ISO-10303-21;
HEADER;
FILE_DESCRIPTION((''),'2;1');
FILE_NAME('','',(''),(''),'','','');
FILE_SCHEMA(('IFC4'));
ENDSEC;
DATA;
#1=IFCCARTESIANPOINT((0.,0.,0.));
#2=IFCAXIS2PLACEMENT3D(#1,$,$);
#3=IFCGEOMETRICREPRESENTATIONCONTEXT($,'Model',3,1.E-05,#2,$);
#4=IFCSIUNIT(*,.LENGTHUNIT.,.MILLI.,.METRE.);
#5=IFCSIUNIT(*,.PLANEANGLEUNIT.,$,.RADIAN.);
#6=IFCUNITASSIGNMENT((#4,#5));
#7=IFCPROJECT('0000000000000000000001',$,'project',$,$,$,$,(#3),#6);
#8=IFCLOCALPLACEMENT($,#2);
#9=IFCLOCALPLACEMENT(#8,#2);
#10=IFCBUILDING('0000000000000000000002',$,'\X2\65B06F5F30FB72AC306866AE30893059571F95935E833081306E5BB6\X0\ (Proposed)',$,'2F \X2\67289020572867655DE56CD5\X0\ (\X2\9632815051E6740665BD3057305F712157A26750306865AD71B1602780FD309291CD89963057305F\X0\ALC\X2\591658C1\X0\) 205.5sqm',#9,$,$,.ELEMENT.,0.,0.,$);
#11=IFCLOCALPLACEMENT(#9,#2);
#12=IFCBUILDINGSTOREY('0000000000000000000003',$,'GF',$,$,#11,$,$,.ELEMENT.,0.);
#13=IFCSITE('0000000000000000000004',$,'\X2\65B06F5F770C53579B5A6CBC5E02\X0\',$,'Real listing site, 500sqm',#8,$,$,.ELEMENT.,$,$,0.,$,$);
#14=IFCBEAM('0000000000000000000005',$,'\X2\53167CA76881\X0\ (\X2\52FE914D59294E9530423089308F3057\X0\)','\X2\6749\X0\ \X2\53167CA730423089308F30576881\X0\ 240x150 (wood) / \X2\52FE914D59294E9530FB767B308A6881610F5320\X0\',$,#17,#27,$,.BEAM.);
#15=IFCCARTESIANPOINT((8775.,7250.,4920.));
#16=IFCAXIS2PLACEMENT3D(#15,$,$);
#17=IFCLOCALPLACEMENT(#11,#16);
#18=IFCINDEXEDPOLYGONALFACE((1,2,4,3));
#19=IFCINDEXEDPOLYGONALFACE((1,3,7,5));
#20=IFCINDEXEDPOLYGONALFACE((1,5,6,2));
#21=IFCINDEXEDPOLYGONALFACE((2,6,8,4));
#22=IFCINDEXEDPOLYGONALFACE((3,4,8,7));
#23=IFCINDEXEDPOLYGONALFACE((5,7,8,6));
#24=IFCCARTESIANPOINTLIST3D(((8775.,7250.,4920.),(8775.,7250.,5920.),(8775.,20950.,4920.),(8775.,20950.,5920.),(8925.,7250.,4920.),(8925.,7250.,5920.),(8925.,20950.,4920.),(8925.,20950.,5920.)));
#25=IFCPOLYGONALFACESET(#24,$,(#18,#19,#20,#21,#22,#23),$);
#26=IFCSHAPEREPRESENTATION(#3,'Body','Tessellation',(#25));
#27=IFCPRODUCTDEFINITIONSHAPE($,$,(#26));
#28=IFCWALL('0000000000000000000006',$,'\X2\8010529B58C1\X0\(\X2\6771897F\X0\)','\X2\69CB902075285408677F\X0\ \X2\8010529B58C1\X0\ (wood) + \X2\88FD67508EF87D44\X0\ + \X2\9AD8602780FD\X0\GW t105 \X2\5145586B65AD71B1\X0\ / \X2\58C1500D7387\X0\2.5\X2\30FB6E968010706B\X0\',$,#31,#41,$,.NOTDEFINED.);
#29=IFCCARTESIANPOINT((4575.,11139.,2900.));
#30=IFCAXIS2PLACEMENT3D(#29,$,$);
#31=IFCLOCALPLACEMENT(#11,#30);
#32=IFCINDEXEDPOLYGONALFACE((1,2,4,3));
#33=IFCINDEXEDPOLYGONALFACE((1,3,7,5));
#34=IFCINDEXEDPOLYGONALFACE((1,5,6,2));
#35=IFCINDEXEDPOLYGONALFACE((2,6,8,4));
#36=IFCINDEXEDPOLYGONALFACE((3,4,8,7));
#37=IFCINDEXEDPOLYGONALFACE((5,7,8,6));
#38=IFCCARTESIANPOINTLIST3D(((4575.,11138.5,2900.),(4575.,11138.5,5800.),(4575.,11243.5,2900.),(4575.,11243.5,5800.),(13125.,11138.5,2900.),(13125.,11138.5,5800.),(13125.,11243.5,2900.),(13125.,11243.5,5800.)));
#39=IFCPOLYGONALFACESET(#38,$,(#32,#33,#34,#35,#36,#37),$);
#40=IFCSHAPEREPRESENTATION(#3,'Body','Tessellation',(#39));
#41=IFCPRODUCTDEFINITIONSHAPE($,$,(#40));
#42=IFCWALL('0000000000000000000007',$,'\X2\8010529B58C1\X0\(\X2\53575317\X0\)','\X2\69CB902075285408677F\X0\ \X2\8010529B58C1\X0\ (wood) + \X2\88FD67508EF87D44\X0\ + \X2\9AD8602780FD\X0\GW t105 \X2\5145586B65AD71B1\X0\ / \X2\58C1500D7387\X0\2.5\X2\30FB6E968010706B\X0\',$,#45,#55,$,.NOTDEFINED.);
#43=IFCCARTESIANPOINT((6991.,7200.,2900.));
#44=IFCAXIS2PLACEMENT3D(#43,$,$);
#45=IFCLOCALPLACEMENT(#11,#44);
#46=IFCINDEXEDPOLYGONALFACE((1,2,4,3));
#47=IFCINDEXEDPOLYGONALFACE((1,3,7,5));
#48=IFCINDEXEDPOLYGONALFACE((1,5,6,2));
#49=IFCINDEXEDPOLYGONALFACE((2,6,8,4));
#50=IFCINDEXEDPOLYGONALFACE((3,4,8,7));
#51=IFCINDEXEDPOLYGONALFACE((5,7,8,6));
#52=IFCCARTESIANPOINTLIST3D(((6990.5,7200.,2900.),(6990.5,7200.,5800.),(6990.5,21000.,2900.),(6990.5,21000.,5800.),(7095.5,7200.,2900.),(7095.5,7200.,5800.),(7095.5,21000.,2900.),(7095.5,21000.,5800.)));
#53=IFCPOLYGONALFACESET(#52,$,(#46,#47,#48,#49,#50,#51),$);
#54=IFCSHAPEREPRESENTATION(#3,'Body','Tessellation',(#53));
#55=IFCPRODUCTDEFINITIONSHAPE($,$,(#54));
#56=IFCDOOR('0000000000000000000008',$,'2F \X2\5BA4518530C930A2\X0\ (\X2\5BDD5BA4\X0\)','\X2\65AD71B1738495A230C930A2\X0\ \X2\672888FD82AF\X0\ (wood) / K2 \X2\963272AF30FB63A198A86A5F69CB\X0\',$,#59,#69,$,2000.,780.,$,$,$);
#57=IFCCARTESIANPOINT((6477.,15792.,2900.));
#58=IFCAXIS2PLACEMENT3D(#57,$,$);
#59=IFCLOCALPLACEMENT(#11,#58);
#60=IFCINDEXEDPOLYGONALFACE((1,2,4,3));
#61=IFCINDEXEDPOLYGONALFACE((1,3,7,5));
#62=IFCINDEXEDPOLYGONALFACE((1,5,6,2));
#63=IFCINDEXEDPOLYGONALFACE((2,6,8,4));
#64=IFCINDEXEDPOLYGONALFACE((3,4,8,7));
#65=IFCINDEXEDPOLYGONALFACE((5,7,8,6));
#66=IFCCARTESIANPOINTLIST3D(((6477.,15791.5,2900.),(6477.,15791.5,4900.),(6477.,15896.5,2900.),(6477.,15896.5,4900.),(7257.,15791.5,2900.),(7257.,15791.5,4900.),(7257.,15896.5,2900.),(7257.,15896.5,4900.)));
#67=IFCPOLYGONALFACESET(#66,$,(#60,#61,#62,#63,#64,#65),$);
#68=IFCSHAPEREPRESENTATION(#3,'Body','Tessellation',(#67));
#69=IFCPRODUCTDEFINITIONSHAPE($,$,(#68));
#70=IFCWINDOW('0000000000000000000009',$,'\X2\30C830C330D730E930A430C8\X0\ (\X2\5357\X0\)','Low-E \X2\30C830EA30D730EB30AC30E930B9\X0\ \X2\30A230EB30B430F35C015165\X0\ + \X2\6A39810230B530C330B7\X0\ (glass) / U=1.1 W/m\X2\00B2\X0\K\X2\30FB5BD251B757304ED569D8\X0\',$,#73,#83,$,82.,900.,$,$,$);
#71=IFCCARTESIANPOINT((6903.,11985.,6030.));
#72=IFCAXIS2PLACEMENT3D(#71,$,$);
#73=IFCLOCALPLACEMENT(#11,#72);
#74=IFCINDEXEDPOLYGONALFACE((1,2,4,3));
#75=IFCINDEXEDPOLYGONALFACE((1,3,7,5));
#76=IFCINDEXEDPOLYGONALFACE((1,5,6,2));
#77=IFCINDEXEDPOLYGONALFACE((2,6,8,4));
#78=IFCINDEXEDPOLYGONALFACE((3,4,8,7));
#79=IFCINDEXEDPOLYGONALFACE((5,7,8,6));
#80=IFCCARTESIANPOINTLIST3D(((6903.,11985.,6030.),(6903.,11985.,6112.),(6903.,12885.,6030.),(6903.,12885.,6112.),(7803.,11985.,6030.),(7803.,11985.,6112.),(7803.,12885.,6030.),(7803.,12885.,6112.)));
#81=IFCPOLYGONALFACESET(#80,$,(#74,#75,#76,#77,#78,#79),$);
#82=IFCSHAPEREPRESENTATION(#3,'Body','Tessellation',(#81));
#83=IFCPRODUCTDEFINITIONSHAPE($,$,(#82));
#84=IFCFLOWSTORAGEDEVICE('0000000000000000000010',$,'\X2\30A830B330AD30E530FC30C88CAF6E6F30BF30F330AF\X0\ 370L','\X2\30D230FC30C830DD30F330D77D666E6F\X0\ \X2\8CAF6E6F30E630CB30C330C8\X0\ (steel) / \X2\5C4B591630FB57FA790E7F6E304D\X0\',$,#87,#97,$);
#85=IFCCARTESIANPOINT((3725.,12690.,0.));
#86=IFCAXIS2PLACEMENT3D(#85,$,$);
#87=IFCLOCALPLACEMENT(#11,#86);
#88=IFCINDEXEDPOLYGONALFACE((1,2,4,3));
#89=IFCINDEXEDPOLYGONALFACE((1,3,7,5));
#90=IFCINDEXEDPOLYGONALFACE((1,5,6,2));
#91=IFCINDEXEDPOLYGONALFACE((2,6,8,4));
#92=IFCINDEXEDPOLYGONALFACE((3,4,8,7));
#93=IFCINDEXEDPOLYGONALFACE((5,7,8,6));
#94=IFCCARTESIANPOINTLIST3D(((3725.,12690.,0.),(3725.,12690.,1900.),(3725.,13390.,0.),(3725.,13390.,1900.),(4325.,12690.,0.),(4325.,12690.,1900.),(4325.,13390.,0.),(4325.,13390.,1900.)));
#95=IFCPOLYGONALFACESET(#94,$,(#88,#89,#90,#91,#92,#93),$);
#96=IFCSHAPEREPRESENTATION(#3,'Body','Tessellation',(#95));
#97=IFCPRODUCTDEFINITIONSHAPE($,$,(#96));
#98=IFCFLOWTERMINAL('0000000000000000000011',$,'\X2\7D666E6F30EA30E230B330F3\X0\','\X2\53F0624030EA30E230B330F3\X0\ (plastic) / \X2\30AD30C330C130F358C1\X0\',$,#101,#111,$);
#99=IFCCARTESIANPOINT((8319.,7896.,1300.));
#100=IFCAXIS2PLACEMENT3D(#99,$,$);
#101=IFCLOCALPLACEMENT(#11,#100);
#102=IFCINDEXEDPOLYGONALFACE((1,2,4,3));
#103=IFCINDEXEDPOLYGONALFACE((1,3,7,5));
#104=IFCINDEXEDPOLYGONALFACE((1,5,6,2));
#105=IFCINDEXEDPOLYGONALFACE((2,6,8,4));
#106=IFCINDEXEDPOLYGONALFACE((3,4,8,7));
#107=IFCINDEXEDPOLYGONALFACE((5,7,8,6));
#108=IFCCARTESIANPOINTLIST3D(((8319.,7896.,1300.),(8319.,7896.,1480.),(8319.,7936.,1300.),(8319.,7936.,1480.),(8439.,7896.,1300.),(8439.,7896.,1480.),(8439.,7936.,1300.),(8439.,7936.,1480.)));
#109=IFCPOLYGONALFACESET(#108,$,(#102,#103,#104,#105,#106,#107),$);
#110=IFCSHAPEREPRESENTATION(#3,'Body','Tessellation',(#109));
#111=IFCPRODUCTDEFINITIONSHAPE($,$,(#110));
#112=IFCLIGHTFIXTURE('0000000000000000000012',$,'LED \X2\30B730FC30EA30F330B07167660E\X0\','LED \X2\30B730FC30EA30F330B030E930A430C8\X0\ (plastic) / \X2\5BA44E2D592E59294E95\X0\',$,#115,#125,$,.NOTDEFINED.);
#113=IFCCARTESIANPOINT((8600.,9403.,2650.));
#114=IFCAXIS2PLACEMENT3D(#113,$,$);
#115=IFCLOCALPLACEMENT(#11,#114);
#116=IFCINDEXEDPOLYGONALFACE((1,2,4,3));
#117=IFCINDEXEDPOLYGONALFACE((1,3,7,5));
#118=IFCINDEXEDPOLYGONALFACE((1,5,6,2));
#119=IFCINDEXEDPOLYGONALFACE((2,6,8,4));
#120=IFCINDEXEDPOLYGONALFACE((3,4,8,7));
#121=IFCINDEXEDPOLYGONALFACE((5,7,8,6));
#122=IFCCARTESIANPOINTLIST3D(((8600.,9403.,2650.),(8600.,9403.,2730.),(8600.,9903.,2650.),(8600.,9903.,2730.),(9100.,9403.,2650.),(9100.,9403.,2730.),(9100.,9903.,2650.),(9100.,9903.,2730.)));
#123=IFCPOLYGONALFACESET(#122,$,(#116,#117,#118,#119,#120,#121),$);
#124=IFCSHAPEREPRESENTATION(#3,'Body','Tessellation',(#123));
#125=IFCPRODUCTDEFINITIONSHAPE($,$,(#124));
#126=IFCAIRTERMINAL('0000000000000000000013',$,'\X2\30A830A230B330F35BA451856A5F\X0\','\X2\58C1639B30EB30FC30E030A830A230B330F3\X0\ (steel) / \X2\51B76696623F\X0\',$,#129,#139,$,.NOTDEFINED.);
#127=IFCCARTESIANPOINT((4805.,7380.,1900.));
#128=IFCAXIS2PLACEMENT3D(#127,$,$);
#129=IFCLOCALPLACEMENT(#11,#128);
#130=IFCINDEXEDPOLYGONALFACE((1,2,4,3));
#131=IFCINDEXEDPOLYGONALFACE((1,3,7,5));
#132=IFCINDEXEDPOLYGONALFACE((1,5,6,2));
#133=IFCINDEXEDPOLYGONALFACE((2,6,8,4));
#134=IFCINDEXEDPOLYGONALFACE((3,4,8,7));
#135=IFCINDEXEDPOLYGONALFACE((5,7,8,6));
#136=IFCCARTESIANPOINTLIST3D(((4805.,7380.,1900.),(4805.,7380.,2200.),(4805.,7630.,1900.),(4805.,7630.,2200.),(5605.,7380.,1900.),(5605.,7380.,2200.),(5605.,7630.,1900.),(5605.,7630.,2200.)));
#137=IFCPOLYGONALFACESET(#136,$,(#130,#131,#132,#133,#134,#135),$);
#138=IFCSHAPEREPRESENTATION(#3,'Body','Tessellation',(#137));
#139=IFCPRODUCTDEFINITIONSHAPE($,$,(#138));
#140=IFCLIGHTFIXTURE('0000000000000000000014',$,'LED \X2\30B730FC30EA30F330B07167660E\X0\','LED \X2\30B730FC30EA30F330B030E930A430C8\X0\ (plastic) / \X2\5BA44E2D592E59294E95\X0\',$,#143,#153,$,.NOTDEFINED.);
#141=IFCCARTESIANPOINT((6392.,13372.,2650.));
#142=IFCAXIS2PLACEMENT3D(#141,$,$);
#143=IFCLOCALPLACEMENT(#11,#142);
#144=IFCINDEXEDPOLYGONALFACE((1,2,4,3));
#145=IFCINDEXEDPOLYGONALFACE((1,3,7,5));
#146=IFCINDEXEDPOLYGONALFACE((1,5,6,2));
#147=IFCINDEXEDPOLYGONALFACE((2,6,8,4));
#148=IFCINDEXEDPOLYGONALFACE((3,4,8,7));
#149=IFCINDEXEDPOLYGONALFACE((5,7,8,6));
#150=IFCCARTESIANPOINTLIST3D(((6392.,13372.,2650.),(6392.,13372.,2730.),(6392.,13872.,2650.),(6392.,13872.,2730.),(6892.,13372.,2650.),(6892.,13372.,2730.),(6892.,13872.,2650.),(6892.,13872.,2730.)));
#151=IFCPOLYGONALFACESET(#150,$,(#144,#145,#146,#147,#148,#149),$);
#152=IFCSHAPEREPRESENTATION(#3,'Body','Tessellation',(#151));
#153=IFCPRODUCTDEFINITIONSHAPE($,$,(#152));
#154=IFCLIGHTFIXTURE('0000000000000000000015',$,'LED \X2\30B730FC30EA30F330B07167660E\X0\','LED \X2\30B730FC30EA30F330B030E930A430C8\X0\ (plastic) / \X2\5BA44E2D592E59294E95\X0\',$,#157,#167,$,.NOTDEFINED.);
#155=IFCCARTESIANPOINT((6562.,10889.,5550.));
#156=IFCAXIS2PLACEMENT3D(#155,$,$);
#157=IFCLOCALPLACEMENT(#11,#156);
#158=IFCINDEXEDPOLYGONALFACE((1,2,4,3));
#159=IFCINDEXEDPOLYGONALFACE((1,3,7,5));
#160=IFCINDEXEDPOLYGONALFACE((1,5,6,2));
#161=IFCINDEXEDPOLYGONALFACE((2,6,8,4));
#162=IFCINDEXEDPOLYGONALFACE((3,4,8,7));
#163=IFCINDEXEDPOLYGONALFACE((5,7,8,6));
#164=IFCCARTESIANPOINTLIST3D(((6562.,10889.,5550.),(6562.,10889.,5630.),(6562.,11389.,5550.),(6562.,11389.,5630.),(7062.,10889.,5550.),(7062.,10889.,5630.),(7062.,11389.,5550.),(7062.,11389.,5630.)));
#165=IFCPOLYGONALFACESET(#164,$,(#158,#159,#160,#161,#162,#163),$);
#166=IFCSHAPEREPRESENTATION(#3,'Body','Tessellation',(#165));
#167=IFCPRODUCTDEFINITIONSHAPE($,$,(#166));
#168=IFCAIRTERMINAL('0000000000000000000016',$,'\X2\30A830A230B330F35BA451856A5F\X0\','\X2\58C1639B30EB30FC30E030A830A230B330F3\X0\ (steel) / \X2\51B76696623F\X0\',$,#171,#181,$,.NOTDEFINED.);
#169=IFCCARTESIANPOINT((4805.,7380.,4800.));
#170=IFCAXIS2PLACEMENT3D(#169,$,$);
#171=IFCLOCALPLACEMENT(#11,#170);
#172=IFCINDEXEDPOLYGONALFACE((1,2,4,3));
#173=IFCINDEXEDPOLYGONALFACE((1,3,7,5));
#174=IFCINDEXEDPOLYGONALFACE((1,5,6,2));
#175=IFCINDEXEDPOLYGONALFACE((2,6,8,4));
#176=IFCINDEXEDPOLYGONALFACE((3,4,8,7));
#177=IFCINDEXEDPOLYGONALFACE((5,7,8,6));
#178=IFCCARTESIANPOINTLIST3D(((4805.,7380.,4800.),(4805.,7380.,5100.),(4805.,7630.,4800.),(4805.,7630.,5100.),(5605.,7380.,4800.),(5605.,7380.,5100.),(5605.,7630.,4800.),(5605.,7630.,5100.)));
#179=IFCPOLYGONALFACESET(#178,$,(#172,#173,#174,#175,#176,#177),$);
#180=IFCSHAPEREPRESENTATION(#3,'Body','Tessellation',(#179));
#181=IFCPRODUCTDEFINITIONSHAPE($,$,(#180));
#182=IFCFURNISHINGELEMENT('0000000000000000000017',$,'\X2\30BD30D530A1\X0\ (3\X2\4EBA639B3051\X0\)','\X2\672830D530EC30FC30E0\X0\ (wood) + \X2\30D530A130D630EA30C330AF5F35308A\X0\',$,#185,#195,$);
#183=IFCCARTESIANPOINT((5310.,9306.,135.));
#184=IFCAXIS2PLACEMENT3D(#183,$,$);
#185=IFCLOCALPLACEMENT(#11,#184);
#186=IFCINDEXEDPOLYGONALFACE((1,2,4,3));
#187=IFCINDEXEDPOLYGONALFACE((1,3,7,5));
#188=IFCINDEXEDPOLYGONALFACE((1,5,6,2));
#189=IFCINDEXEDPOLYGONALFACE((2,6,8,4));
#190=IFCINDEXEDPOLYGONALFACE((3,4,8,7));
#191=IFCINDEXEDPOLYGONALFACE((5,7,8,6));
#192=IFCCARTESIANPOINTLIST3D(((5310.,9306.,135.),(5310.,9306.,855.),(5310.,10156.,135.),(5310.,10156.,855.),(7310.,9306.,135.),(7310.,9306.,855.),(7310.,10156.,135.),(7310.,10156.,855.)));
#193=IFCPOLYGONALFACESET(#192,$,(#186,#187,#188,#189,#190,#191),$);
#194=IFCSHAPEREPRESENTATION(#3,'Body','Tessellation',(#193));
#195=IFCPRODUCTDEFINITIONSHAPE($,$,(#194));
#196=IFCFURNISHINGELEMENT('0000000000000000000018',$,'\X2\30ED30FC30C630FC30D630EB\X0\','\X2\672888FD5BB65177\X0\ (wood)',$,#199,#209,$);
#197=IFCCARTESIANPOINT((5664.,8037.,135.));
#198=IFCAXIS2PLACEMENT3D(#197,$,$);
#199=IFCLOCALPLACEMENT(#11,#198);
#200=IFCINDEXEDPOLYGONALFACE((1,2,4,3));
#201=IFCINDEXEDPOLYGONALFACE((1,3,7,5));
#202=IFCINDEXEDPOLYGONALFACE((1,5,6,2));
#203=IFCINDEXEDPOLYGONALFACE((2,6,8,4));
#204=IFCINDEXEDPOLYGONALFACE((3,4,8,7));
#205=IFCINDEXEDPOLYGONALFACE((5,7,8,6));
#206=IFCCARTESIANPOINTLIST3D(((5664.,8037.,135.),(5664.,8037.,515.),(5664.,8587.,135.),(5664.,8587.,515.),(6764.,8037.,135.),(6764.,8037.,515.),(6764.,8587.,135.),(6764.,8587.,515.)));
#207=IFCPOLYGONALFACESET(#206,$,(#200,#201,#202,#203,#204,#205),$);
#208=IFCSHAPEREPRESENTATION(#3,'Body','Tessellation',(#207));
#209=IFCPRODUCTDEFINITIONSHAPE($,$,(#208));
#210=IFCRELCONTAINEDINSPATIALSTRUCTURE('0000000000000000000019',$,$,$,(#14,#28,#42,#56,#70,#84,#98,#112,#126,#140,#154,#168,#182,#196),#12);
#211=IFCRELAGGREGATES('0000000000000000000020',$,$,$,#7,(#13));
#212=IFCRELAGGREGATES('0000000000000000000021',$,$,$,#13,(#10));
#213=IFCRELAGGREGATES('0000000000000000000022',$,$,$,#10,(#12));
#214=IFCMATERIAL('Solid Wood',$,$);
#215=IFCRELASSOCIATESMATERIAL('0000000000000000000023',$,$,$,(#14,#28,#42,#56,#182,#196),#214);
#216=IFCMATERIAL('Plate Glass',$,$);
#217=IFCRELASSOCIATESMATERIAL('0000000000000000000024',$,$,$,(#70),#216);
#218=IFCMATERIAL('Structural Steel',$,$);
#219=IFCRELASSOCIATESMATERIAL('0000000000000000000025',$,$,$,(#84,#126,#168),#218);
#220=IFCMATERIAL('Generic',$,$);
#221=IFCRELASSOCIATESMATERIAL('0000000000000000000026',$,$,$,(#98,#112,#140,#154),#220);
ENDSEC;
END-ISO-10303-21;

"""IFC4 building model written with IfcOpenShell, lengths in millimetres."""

from ifc_helpers import new_model, si_unit, frame, frame_2d, origin, place, context, project, spatial, rectangle, extrude, material, element, fill, save


model = new_model("IFC4")

# Units and contexts
model_context = context("Model", 3, precision=1e-05, world=origin())
ifc_project = project(units=[si_unit("LENGTHUNIT", "METRE", prefix="MILLI"), si_unit("PLANEANGLEUNIT", "RADIAN")], contexts=[model_context])

# Site, building, storey
site_placement = place(None, origin())
site = spatial("IfcSite", under=ifc_project, at=site_placement, Name="新潟県南魚沼市", ObjectType="Real listing site, 500sqm", CompositionType="ELEMENT", RefElevation=0.0)
building_placement = place(site_placement, origin())
building = spatial("IfcBuilding", under=site, at=building_placement, Name="新潟・犬と暮らす土間広めの家 (Proposed)", ObjectType="2F 木造在来工法 (防腐処理施した無垢材と断熱性能を重視したALC外壁) 205.5sqm", CompositionType="ELEMENT", ElevationOfRefHeight=0.0, ElevationOfTerrain=0.0)
storey_placement = place(building_placement, origin())
storey = spatial("IfcBuildingStorey", under=building, at=storey_placement, Name="GF", CompositionType="ELEMENT", Elevation=0.0)

# Shared definitions
ifc_material_1 = material(Name="Solid Wood")

# Beam
beam_placement = place(storey_placement, frame((8775.0, 7250.0, 4920.0)))
element("IfcBeam", 1, at=beam_placement, inside=storey, material=ifc_material_1, Name="化粧梁 (勾配天井あらわし)", Description="杉 化粧あらわし梁 240x150 (wood) / 勾配天井・登り梁意匠", PredefinedType="BEAM", context=model_context, shape_type="SweptSolid", body=[
    extrude(rectangle(XDim=150.0, YDim=13700.0, at=frame_2d((75.0, 6850.0))), frame((8775.0, 7250.0, 4920.0)), (0.0, 0.0, 1.0), 1000.0),
])

# Wall
wall_1_placement = place(storey_placement, frame((4575.0, 11139.0, 2900.0)))
element("IfcWall", 2, at=wall_1_placement, inside=storey, material=ifc_material_1, Name="耐力壁(東西)", Description="構造用合板 耐力壁 (wood) + 製材軸組 + 高性能GW t105 充填断熱 / 壁倍率2.5・準耐火", PredefinedType="NOTDEFINED", context=model_context, shape_type="SweptSolid", body=[
    extrude(rectangle(XDim=8550.0, YDim=105.0, at=frame_2d((4275.0, 52.0))), frame((4575.0, 11139.0, 2900.0)), (0.0, 0.0, 1.0), 2900.0),
])

# Wall, opening, door
wall_2_placement = place(storey_placement, frame((6991.0, 7200.0, 2900.0)))
wall_2 = element("IfcWall", 3, at=wall_2_placement, inside=storey, material=ifc_material_1, Name="耐力壁(南北)", Description="構造用合板 耐力壁 (wood) + 製材軸組 + 高性能GW t105 充填断熱 / 壁倍率2.5・準耐火", PredefinedType="NOTDEFINED", context=model_context, shape_type="SweptSolid", body=[
    extrude(rectangle(XDim=105.0, YDim=13800.0, at=frame_2d((52.0, 6900.0))), frame((6991.0, 7200.0, 2900.0)), (0.0, 0.0, 1.0), 2900.0),
])
opening_placement = place(storey_placement, frame((6477.0, 15792.0, 2900.0)))
opening = element("IfcOpeningElement", 4, at=opening_placement, cuts=wall_2, PredefinedType="NOTDEFINED", context=model_context, shape_type="SweptSolid", body=[
    extrude(rectangle(XDim=780.0, YDim=105.0, at=frame_2d((390.0, 52.0))), frame((6477.0, 15792.0, 2900.0)), (0.0, 0.0, 1.0), 2000.0),
])
door_placement = place(storey_placement, frame((6477.0, 15792.0, 2900.0)))
door = element("IfcDoor", 5, at=door_placement, inside=storey, material=ifc_material_1, Name="2F 室内ドア (寝室)", Description="断熱玄関ドア 木製芯 (wood) / K2 防犯・採風機構", OverallHeight=2000.0, OverallWidth=780.0, context=model_context, shape_type="SweptSolid", body=[
    extrude(rectangle(XDim=780.0, YDim=105.0, at=frame_2d((390.0, 52.0))), frame((6477.0, 15792.0, 2900.0)), (0.0, 0.0, 1.0), 2000.0),
])
fill(opening, door)

# Window
ifc_material_2 = material(Name="Plate Glass")
window_placement = place(storey_placement, frame((6903.0, 11985.0, 6030.0)))
element("IfcWindow", 6, at=window_placement, inside=storey, material=ifc_material_2, Name="トップライト (南)", Description="Low-E トリプルガラス アルゴン封入 + 樹脂サッシ (glass) / U=1.1 W/m²K・寒冷地仕様", OverallHeight=82.0, OverallWidth=900.0, context=model_context, shape_type="SweptSolid", body=[
    extrude(rectangle(XDim=900.0, YDim=900.0, at=frame_2d((450.0, 450.0))), frame((6903.0, 11985.0, 6030.0)), (0.0, 0.0, 1.0), 82.0),
])

# Flow storage device
ifc_material_3 = material(Name="Structural Steel")
flow_storage_device_placement = place(storey_placement, frame((3725.0, 12690.0, 0.0)))
element("IfcFlowStorageDevice", 7, at=flow_storage_device_placement, inside=storey, material=ifc_material_3, Name="エコキュート貯湯タンク 370L", Description="ヒートポンプ給湯 貯湯ユニット (steel) / 屋外・基礎置き", context=model_context, shape_type="SweptSolid", body=[
    extrude(rectangle(XDim=600.0, YDim=700.0, at=frame_2d((300.0, 350.0))), frame((3725.0, 12690.0, 0.0)), (0.0, 0.0, 1.0), 1900.0),
])

# Flow terminal
ifc_material_4 = material(Name="Generic")
flow_terminal_placement = place(storey_placement, frame((8319.0, 7896.0, 1300.0)))
element("IfcFlowTerminal", 8, at=flow_terminal_placement, inside=storey, material=ifc_material_4, Name="給湯リモコン", Description="台所リモコン (plastic) / キッチン壁", context=model_context, shape_type="SweptSolid", body=[
    extrude(rectangle(XDim=120.0, YDim=40.0, at=frame_2d((60.0, 20.0))), frame((8319.0, 7896.0, 1300.0)), (0.0, 0.0, 1.0), 180.0),
])

# Light fixture
light_fixture_1_placement = place(storey_placement, frame((8600.0, 9403.0, 2650.0)))
element("IfcLightFixture", 9, at=light_fixture_1_placement, inside=storey, material=ifc_material_4, Name="LED シーリング照明", Description="LED シーリングライト (plastic) / 室中央天井", PredefinedType="NOTDEFINED", context=model_context, shape_type="SweptSolid", body=[
    extrude(rectangle(XDim=500.0, YDim=500.0, at=frame_2d((250.0, 250.0))), frame((8600.0, 9403.0, 2650.0)), (0.0, 0.0, 1.0), 80.0),
])

# Air terminal
air_terminal_1_placement = place(storey_placement, frame((4805.0, 7380.0, 1900.0)))
element("IfcAirTerminal", 10, at=air_terminal_1_placement, inside=storey, material=ifc_material_3, Name="エアコン室内機", Description="壁掛ルームエアコン (steel) / 冷暖房", PredefinedType="NOTDEFINED", context=model_context, shape_type="SweptSolid", body=[
    extrude(rectangle(XDim=800.0, YDim=250.0, at=frame_2d((400.0, 125.0))), frame((4805.0, 7380.0, 1900.0)), (0.0, 0.0, 1.0), 300.0),
])

# Light fixtures
light_fixture_2_placement = place(storey_placement, frame((6392.0, 13372.0, 2650.0)))
element("IfcLightFixture", 11, at=light_fixture_2_placement, inside=storey, material=ifc_material_4, Name="LED シーリング照明", Description="LED シーリングライト (plastic) / 室中央天井", PredefinedType="NOTDEFINED", context=model_context, shape_type="SweptSolid", body=[
    extrude(rectangle(XDim=500.0, YDim=500.0, at=frame_2d((250.0, 250.0))), frame((6392.0, 13372.0, 2650.0)), (0.0, 0.0, 1.0), 80.0),
])
light_fixture_3_placement = place(storey_placement, frame((6562.0, 10889.0, 5550.0)))
element("IfcLightFixture", 12, at=light_fixture_3_placement, inside=storey, material=ifc_material_4, Name="LED シーリング照明", Description="LED シーリングライト (plastic) / 室中央天井", PredefinedType="NOTDEFINED", context=model_context, shape_type="SweptSolid", body=[
    extrude(rectangle(XDim=500.0, YDim=500.0, at=frame_2d((250.0, 250.0))), frame((6562.0, 10889.0, 5550.0)), (0.0, 0.0, 1.0), 80.0),
])

# Air terminal
air_terminal_2_placement = place(storey_placement, frame((4805.0, 7380.0, 4800.0)))
element("IfcAirTerminal", 13, at=air_terminal_2_placement, inside=storey, material=ifc_material_3, Name="エアコン室内機", Description="壁掛ルームエアコン (steel) / 冷暖房", PredefinedType="NOTDEFINED", context=model_context, shape_type="SweptSolid", body=[
    extrude(rectangle(XDim=800.0, YDim=250.0, at=frame_2d((400.0, 125.0))), frame((4805.0, 7380.0, 4800.0)), (0.0, 0.0, 1.0), 300.0),
])

# Furnishing elements
furnishing_1_placement = place(storey_placement, frame((5310.0, 9306.0, 135.0)))
element("IfcFurnishingElement", 14, at=furnishing_1_placement, inside=storey, material=ifc_material_1, Name="ソファ (3人掛け)", Description="木フレーム (wood) + ファブリック張り", context=model_context, shape_type="SweptSolid", body=[
    extrude(rectangle(XDim=2000.0, YDim=850.0, at=frame_2d((1000.0, 425.0))), frame((5310.0, 9306.0, 135.0)), (0.0, 0.0, 1.0), 720.0),
])
furnishing_2_placement = place(storey_placement, frame((5664.0, 8037.0, 135.0)))
element("IfcFurnishingElement", 15, at=furnishing_2_placement, inside=storey, material=ifc_material_1, Name="ローテーブル", Description="木製家具 (wood)", context=model_context, shape_type="SweptSolid", body=[
    extrude(rectangle(XDim=1100.0, YDim=550.0, at=frame_2d((550.0, 275.0))), frame((5664.0, 8037.0, 135.0)), (0.0, 0.0, 1.0), 380.0),
])

save(model, "model.ifc")
